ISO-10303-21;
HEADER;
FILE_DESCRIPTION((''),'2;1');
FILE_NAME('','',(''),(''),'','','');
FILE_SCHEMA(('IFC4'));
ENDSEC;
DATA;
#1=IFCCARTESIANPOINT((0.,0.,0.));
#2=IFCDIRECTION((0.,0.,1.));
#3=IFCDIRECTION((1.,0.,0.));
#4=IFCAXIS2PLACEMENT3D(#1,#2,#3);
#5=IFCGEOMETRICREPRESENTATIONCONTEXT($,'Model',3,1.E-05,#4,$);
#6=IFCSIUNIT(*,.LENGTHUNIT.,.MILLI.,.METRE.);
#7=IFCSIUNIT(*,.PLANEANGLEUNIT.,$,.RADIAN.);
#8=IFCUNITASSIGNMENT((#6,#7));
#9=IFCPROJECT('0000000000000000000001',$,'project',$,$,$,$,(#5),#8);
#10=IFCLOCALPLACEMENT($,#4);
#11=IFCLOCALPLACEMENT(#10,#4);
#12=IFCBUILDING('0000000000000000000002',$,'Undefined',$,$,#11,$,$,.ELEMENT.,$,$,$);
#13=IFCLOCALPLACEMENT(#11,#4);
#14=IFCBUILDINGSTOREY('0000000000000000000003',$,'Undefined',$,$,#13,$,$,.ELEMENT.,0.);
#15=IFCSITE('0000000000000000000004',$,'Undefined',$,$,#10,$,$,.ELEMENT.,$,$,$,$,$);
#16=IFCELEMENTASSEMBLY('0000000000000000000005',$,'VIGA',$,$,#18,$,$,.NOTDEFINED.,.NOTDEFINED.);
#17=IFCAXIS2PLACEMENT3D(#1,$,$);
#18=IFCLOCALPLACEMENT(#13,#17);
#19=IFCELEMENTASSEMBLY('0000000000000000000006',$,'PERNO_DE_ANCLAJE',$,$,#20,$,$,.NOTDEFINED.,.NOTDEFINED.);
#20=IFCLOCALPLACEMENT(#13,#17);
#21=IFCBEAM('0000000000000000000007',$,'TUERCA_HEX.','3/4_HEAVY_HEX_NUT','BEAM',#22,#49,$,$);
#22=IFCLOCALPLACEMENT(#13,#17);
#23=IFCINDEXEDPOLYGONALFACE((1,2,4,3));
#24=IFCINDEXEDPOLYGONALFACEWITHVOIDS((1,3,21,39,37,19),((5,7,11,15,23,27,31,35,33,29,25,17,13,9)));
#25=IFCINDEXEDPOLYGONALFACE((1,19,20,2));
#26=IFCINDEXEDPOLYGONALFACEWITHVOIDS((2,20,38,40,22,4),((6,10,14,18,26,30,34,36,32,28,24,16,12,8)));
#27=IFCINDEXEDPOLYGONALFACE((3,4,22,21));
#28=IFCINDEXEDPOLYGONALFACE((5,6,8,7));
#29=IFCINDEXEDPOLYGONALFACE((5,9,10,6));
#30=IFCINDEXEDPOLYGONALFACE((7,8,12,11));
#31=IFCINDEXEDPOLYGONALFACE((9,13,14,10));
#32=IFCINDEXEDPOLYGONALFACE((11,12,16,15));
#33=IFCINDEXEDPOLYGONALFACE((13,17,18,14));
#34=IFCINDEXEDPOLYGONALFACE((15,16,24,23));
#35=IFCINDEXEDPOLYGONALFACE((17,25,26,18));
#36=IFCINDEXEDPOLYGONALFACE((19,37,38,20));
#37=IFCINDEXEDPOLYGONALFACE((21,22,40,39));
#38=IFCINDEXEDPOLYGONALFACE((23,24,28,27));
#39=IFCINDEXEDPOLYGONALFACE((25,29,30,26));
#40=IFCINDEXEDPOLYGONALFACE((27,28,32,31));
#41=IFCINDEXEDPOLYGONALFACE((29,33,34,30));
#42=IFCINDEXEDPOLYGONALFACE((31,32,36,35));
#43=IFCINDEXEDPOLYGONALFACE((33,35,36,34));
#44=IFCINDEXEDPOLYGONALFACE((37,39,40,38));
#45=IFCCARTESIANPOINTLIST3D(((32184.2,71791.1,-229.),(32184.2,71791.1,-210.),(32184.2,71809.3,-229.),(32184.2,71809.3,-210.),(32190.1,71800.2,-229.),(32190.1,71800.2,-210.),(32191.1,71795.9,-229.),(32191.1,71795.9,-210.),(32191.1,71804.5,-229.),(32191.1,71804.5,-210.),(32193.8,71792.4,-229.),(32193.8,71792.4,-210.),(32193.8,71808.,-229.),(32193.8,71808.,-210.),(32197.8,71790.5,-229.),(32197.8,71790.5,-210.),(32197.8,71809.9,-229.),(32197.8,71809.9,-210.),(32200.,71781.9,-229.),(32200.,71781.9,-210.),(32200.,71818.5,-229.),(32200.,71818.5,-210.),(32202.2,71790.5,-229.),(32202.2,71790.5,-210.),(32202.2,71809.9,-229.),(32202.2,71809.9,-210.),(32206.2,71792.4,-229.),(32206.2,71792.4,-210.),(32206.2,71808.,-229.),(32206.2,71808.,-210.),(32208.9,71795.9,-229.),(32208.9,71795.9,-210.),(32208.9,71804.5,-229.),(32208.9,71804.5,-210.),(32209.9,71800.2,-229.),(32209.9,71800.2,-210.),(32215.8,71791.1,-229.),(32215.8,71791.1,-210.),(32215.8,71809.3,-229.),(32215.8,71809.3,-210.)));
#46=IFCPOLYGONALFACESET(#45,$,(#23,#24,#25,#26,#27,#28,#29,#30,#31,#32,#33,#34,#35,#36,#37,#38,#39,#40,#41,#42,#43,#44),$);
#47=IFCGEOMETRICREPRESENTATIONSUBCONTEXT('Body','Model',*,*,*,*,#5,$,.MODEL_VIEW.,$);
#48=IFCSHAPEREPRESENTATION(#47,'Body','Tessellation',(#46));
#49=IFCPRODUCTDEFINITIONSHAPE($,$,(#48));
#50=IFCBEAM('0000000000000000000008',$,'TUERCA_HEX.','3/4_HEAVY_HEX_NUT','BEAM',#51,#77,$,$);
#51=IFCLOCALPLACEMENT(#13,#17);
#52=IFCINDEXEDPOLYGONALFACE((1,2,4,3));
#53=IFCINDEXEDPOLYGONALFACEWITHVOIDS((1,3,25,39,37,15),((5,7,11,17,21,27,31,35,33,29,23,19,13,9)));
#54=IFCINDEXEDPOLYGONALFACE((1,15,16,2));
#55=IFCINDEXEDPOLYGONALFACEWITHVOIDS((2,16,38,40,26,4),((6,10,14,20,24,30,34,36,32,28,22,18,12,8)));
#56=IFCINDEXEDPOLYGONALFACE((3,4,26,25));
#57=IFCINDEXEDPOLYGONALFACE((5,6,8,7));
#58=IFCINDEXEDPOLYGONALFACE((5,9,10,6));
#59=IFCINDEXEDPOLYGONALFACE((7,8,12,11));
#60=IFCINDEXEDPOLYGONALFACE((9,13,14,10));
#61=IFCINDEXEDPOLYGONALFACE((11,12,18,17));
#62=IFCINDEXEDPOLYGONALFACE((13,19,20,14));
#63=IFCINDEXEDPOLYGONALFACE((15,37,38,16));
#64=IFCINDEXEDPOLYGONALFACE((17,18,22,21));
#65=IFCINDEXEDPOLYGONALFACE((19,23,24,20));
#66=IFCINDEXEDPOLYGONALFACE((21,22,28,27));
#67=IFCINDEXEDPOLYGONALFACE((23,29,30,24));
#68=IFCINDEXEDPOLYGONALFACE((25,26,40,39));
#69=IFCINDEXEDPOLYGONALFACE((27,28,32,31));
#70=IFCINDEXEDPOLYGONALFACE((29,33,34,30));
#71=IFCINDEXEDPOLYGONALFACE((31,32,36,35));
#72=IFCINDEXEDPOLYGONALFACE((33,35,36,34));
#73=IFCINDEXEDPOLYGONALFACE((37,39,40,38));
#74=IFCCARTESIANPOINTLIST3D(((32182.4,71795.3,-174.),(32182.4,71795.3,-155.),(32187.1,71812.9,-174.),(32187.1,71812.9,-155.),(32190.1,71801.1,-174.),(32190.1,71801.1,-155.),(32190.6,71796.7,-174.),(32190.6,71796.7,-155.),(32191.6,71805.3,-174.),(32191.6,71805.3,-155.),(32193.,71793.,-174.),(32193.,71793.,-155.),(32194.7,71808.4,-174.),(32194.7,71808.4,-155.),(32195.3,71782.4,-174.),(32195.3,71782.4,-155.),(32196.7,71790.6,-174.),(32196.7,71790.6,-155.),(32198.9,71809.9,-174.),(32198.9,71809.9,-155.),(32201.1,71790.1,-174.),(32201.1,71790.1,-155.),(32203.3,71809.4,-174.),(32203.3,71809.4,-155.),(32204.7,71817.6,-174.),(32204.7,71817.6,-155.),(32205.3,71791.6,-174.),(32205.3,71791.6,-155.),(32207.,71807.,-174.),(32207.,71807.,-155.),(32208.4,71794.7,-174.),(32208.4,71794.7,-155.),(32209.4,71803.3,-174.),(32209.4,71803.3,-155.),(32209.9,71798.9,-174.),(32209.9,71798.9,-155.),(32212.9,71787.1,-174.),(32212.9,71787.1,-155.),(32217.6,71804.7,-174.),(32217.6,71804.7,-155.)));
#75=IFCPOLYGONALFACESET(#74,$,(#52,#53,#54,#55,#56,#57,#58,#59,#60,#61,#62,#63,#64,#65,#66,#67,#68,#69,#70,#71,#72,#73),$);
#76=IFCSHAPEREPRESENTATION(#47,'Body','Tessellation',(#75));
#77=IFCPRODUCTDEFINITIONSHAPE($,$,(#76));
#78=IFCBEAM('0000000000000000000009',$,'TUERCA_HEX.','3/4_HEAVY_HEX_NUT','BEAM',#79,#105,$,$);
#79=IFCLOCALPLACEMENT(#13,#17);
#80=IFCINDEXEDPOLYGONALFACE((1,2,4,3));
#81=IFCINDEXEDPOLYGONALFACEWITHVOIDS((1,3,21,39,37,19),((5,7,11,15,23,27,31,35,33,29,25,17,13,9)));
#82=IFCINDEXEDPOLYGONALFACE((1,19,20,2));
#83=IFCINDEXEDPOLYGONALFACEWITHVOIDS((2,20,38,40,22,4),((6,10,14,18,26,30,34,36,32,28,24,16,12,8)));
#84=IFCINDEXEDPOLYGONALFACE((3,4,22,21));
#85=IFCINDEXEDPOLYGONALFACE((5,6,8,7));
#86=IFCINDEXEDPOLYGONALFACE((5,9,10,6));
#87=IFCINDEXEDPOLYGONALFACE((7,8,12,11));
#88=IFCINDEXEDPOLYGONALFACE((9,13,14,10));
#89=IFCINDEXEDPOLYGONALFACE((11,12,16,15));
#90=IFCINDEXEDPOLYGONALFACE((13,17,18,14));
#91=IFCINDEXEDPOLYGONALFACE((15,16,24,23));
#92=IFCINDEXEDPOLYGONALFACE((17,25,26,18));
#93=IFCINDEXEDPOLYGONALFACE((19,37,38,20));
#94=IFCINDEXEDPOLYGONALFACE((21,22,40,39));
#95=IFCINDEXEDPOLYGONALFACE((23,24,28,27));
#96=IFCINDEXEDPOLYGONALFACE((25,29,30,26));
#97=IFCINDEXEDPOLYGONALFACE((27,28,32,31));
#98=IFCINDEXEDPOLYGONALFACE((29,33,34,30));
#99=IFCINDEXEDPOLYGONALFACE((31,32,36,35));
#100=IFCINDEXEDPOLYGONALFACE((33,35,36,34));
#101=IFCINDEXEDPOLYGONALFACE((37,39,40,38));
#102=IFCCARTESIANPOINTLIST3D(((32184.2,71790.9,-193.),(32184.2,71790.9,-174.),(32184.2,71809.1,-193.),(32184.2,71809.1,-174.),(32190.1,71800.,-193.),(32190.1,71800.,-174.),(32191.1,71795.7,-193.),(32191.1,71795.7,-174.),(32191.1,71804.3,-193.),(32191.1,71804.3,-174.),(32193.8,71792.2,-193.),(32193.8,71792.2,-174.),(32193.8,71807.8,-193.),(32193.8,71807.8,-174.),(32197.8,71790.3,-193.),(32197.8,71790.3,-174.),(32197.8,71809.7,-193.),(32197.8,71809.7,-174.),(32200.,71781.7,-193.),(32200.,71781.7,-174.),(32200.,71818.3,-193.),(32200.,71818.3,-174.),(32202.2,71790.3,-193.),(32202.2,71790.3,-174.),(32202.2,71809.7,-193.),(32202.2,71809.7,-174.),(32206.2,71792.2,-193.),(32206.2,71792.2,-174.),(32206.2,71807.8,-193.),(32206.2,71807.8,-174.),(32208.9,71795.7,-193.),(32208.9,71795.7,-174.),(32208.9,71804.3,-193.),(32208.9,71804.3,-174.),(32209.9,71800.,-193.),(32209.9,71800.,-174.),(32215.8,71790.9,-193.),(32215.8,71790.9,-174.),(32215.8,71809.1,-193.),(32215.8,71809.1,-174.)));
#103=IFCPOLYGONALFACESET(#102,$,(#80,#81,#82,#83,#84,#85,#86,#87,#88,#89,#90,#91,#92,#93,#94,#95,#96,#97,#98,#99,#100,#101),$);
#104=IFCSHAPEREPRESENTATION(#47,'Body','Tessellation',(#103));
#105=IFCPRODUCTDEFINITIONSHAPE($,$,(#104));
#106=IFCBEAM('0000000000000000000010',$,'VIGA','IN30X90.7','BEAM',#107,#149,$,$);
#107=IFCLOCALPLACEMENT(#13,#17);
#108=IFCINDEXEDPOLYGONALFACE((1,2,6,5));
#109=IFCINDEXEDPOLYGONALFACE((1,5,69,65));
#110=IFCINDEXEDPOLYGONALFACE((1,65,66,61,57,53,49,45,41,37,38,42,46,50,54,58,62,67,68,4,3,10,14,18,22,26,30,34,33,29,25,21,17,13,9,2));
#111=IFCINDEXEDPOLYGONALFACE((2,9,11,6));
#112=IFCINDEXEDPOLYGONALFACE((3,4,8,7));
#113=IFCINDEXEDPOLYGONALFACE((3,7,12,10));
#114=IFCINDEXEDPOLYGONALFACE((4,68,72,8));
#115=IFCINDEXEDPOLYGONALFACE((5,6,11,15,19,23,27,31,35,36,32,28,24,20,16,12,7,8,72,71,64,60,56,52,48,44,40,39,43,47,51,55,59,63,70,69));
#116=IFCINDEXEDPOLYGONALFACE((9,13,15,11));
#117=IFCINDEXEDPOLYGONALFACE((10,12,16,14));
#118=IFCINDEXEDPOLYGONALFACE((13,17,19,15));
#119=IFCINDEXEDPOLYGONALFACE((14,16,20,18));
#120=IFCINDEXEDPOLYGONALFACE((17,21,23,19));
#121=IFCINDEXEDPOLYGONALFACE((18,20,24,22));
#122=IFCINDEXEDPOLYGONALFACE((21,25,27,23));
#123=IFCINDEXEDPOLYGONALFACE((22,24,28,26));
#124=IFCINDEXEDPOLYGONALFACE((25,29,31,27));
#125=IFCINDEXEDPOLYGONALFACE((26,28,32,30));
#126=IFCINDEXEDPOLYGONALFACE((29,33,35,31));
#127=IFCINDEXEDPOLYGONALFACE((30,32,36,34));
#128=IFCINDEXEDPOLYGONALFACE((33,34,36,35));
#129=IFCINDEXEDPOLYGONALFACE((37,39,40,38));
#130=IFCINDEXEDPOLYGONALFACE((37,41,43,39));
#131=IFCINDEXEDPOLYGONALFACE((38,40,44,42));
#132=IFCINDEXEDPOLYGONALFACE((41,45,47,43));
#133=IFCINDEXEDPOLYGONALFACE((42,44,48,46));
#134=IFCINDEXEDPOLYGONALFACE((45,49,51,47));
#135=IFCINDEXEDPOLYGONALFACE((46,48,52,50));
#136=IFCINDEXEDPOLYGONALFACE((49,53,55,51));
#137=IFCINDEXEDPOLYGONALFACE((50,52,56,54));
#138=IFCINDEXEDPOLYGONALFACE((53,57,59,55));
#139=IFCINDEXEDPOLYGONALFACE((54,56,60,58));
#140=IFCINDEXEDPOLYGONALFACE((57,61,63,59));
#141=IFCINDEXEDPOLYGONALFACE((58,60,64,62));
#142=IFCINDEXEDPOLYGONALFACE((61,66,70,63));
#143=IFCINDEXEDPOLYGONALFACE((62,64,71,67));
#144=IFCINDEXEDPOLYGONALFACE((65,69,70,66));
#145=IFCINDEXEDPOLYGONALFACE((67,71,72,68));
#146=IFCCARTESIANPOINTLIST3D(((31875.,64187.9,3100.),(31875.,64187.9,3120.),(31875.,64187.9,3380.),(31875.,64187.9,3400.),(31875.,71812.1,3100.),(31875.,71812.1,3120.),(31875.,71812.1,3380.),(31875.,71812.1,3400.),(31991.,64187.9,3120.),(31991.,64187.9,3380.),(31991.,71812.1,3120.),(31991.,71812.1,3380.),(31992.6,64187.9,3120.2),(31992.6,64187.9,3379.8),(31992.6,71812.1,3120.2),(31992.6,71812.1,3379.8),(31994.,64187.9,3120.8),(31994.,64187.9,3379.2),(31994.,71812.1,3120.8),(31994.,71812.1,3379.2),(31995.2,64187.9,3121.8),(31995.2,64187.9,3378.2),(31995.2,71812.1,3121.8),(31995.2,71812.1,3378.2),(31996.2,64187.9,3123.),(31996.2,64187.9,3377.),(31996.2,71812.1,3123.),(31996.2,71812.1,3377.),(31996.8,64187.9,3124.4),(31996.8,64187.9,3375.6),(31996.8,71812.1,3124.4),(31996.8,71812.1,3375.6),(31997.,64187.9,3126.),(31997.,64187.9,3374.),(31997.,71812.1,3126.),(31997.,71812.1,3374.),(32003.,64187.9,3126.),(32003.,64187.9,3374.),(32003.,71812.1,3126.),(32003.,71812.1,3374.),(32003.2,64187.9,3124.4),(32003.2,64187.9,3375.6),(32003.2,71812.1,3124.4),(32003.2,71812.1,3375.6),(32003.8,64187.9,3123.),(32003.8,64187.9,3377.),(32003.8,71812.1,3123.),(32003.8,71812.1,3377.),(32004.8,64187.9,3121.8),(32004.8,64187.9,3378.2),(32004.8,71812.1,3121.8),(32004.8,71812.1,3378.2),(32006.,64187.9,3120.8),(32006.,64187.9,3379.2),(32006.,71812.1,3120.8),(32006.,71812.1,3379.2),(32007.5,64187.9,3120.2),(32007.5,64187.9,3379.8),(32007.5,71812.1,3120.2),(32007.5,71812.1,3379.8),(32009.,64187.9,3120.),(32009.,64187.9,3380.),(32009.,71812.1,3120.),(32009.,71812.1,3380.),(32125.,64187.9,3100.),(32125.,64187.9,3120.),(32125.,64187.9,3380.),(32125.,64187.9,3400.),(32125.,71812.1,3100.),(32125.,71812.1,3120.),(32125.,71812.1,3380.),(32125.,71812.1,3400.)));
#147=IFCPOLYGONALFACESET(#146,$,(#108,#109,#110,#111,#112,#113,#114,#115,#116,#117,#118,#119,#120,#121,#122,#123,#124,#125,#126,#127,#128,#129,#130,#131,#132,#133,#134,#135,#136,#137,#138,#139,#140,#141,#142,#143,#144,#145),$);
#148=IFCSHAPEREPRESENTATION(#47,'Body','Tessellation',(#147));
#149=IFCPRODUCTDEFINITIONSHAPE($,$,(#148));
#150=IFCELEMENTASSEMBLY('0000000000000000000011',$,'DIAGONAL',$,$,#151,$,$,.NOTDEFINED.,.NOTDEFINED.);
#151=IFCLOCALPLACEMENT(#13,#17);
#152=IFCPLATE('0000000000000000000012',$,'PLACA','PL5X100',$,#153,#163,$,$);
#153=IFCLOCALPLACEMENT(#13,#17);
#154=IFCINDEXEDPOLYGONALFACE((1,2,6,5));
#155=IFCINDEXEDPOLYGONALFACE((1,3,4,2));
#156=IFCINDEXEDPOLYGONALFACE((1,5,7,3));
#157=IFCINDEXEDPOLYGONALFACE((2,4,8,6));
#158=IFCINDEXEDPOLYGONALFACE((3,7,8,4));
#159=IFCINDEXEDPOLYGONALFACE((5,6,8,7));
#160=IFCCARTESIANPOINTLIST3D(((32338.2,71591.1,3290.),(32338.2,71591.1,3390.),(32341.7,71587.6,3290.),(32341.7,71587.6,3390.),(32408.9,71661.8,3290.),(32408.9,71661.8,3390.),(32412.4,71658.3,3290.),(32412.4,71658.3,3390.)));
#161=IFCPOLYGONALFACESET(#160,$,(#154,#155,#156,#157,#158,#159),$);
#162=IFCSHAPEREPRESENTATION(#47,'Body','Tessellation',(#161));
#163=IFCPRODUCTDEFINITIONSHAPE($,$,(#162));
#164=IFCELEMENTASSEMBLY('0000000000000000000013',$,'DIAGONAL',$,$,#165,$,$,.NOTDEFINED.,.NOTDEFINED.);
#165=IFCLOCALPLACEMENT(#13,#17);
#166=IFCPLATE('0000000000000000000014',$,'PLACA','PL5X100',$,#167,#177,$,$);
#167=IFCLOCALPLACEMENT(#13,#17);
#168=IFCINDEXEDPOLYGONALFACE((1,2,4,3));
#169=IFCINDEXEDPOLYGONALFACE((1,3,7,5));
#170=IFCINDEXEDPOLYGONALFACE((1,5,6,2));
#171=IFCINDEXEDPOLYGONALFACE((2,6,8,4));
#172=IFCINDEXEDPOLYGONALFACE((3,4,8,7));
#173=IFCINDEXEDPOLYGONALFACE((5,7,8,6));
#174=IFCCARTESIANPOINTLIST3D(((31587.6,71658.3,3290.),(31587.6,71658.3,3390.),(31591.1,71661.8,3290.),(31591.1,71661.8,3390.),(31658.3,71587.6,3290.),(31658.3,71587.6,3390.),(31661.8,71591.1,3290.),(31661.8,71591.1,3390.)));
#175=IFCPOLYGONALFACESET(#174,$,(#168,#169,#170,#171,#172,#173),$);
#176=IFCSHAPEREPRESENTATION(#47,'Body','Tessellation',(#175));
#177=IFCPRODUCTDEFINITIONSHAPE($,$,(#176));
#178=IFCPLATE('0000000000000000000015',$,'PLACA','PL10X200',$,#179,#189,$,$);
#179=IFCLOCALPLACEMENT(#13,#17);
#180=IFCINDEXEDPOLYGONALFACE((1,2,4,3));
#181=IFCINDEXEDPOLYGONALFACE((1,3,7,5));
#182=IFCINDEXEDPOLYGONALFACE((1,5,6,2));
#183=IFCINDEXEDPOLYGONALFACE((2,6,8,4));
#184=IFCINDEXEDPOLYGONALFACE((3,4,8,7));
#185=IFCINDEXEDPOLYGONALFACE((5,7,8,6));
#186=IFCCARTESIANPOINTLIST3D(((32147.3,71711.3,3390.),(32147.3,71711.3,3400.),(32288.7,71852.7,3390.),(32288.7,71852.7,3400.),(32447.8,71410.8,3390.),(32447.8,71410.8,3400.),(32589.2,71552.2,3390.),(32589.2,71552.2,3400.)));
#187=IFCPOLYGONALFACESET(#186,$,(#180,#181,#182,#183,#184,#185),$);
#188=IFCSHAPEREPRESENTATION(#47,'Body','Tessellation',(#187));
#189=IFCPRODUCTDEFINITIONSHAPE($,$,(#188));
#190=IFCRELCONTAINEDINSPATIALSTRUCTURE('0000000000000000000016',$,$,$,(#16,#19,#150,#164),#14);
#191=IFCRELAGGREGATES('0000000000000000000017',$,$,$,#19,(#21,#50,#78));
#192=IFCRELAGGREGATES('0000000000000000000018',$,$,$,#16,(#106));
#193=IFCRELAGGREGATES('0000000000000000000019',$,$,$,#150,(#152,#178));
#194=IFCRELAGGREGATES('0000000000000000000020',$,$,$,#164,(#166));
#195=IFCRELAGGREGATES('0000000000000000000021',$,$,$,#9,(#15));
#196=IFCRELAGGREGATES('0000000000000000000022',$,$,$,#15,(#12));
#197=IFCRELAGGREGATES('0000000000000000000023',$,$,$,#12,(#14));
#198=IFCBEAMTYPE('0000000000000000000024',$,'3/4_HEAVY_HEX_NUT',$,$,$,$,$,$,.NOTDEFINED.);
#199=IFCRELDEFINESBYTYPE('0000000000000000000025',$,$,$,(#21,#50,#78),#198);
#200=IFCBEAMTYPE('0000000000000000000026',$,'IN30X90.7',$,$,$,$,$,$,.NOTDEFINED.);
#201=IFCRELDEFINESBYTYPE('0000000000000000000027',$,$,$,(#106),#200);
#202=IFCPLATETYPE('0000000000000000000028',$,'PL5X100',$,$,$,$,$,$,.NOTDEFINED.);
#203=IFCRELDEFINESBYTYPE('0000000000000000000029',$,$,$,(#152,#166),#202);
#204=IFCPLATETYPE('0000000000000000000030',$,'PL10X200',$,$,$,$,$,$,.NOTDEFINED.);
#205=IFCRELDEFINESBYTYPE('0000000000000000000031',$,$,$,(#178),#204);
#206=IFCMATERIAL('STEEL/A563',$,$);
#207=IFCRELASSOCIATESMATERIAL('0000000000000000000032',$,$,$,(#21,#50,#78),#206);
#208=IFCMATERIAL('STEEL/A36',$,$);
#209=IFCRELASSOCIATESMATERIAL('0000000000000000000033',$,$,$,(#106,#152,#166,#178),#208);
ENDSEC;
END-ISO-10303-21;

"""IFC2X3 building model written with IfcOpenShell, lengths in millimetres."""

from ifc_helpers import new_model, si_unit, frame, origin_with_axes, origin_2d_with_axis, place, context, subcontext, project, spatial, polyline, i_section, outline, extrude, material, type_object, element, aggregate, save


model = new_model("IFC2X3")

# Units and contexts
model_context = context("Model", 3, precision=1e-05, world=origin_with_axes())
body_context = subcontext(model_context, "Body", "Model", "MODEL_VIEW")
ifc_project = project(units=[si_unit("LENGTHUNIT", "METRE", prefix="MILLI"), si_unit("PLANEANGLEUNIT", "RADIAN")], contexts=[model_context])

# Site, building, storey
site_placement = place(None, origin_with_axes())
site = spatial("IfcSite", under=ifc_project, at=site_placement, Name="Undefined", CompositionType="ELEMENT")
building_placement = place(site_placement, origin_with_axes())
building = spatial("IfcBuilding", under=site, at=building_placement, Name="Undefined", CompositionType="ELEMENT")
storey_placement = place(building_placement, origin_with_axes())
storey = spatial("IfcBuildingStorey", under=building, at=storey_placement, Name="Undefined", CompositionType="ELEMENT", Elevation=0.0)

# Element assemblies
assembly_1_placement = place(storey_placement, origin_with_axes())
assembly_1 = element("IfcElementAssembly", 1, at=assembly_1_placement, inside=storey, Name="VIGA", AssemblyPlace="NOTDEFINED", PredefinedType="NOTDEFINED")
ifc_material_1 = material(Name="STEEL/A36")
ifc_material_2 = material(Name="STEEL/A563")
assembly_2_placement = place(storey_placement, origin_with_axes())
assembly_2 = element("IfcElementAssembly", 2, at=assembly_2_placement, inside=storey, Name="PERNO_DE_ANCLAJE", AssemblyPlace="NOTDEFINED", PredefinedType="NOTDEFINED")

# Beams
beam_type_1 = type_object("IfcBeamType", Name="3/4_HEAVY_HEX_NUT", PredefinedType="NOTDEFINED")
beam_1_placement = place(assembly_2_placement, frame((32200.0, 71800.2, -210.0), z_axis=(1.0, 0.0, 0.0), x_axis=(0.0, 0.0, -1.0)))
beam_1 = element("IfcBeam", 3, at=beam_1_placement, type_object=beam_type_1, material=ifc_material_2, Name="TUERCA_HEX.", Description="3/4_HEAVY_HEX_NUT", ObjectType="BEAM", context=body_context, shape_type="SweptSolid", body=[
    extrude(outline(polyline([(-9.1, -15.8), (-18.3, 0.0), (-9.1, 15.8), (9.1, 15.8), (18.3, 0.0), (9.1, -15.8), (-9.1, -15.8)]), holes=[polyline([(7.8, 6.2), (4.3, 8.9), (0.0, 9.9), (-4.3, 8.9), (-7.8, 6.2), (-9.7, 2.2), (-9.7, -2.2), (-7.8, -6.2), (-4.3, -8.9), (0.0, -9.9), (4.3, -8.9), (7.8, -6.2), (9.7, -2.2), (9.7, 2.2), (7.8, 6.2)])]), frame((19.0, 0.0, 0.0), z_axis=(-1.0, 0.0, 0.0), x_axis=(0.0, -1.0, 0.0)), (0.0, 0.0, 1.0), 19.0),
])
beam_2_placement = place(assembly_2_placement, frame((32200.0, 71800.0, -155.0), z_axis=(0.707107, 0.707107, 0.0), x_axis=(0.0, 0.0, -1.0)))
beam_2 = element("IfcBeam", 4, at=beam_2_placement, type_object=beam_type_1, material=ifc_material_2, Name="TUERCA_HEX.", Description="3/4_HEAVY_HEX_NUT", ObjectType="BEAM", context=body_context, shape_type="SweptSolid", body=[
    extrude(outline(polyline([(-9.1, -15.8), (-18.3, 0.0), (-9.1, 15.8), (9.1, 15.8), (18.3, 0.0), (9.1, -15.8), (-9.1, -15.8)]), holes=[polyline([(7.8, 6.2), (4.3, 8.9), (0.0, 9.9), (-4.3, 8.9), (-7.8, 6.2), (-9.7, 2.2), (-9.7, -2.2), (-7.8, -6.2), (-4.3, -8.9), (0.0, -9.9), (4.3, -8.9), (7.8, -6.2), (9.7, -2.2), (9.7, 2.2), (7.8, 6.2)])]), frame((19.0, 0.0, 0.0), z_axis=(-1.0, 0.0, 0.0), x_axis=(0.0, -1.0, 0.0)), (0.0, 0.0, 1.0), 19.0),
])
beam_3_placement = place(assembly_2_placement, frame((32200.0, 71800.0, -174.0), z_axis=(1.0, 0.0, 0.0), x_axis=(0.0, 0.0, -1.0)))
beam_3 = element("IfcBeam", 5, at=beam_3_placement, type_object=beam_type_1, material=ifc_material_2, Name="TUERCA_HEX.", Description="3/4_HEAVY_HEX_NUT", ObjectType="BEAM", context=body_context, shape_type="SweptSolid", body=[
    extrude(outline(polyline([(-9.1, -15.8), (-18.3, 0.0), (-9.1, 15.8), (9.1, 15.8), (18.3, 0.0), (9.1, -15.8), (-9.1, -15.8)]), holes=[polyline([(7.8, 6.2), (4.3, 8.9), (0.0, 9.9), (-4.3, 8.9), (-7.8, 6.2), (-9.7, 2.2), (-9.7, -2.2), (-7.8, -6.2), (-4.3, -8.9), (0.0, -9.9), (4.3, -8.9), (7.8, -6.2), (9.7, -2.2), (9.7, 2.2), (7.8, 6.2)])]), frame((19.0, 0.0, 0.0), z_axis=(-1.0, 0.0, 0.0), x_axis=(0.0, -1.0, 0.0)), (0.0, 0.0, 1.0), 19.0),
])
aggregate(assembly_2, [beam_1, beam_2, beam_3])
beam_type_2 = type_object("IfcBeamType", Name="IN30X90.7", PredefinedType="NOTDEFINED")
beam_4_placement = place(assembly_1_placement, frame((32000.0, 71812.1, 3250.0), z_axis=(0.0, 0.0, 1.0), x_axis=(0.0, -1.0, 0.0)))
beam_4 = element("IfcBeam", 6, at=beam_4_placement, type_object=beam_type_2, material=ifc_material_1, Name="VIGA", Description="IN30X90.7", ObjectType="BEAM", context=body_context, shape_type="SweptSolid", body=[
    extrude(i_section(OverallWidth=250.0, OverallDepth=300.0, WebThickness=6.0, FlangeThickness=20.0, FilletRadius=6.0, at=origin_2d_with_axis()), frame((7624.2, 0.0, 0.0), z_axis=(-1.0, 0.0, 0.0), x_axis=(0.0, -1.0, 0.0)), (0.0, 0.0, 1.0), 7624.2),
])

# Element assemblies, plates
assembly_3_placement = place(storey_placement, origin_with_axes())
assembly_3 = element("IfcElementAssembly", 7, at=assembly_3_placement, inside=storey, Name="DIAGONAL", AssemblyPlace="NOTDEFINED", PredefinedType="NOTDEFINED")
plate_type_1 = type_object("IfcPlateType", Name="PL5X100", PredefinedType="NOTDEFINED")
plate_1_placement = place(assembly_3_placement, frame((32339.9, 71589.4, 3390.0), z_axis=(0.707107, -0.707107, 0.0), x_axis=(0.0, 0.0, -1.0)))
plate_1 = element("IfcPlate", 8, at=plate_1_placement, type_object=plate_type_1, material=ifc_material_1, Name="PLACA", Description="PL5X100", context=body_context, shape_type="SweptSolid", body=[
    extrude(outline(polyline([(0.0, 0.0), (100.0, 0.0), (100.0, 100.0), (0.0, 100.0), (0.0, 0.0)])), frame((0.0, 0.0, -2.5), z_axis=(0.0, 0.0, 1.0), x_axis=(1.0, 0.0, 0.0)), (0.0, 0.0, 1.0), 5.0),
])
assembly_4_placement = place(storey_placement, origin_with_axes())
assembly_4 = element("IfcElementAssembly", 9, at=assembly_4_placement, inside=storey, Name="DIAGONAL", AssemblyPlace="NOTDEFINED", PredefinedType="NOTDEFINED")
plate_2_placement = place(assembly_4_placement, frame((31589.4, 71660.1, 3390.0), z_axis=(-0.707107, -0.707107, 0.0), x_axis=(0.0, 0.0, -1.0)))
plate_2 = element("IfcPlate", 10, at=plate_2_placement, type_object=plate_type_1, material=ifc_material_1, Name="PLACA", Description="PL5X100", context=body_context, shape_type="SweptSolid", body=[
    extrude(outline(polyline([(0.0, 0.0), (100.0, 0.0), (100.0, 100.0), (0.0, 100.0), (0.0, 0.0)])), frame((0.0, 0.0, -2.5), z_axis=(0.0, 0.0, 1.0), x_axis=(1.0, 0.0, 0.0)), (0.0, 0.0, 1.0), 5.0),
])

# Plate
plate_type_2 = type_object("IfcPlateType", Name="PL10X200", PredefinedType="NOTDEFINED")
plate_3_placement = place(assembly_3_placement, frame((32218.0, 71782.0, 3395.0), z_axis=(0.0, 0.0, -1.0), x_axis=(0.707107, -0.707107, 0.0)))
plate_3 = element("IfcPlate", 11, at=plate_3_placement, type_object=plate_type_2, material=ifc_material_1, Name="PLACA", Description="PL10X200", context=body_context, shape_type="SweptSolid", body=[
    extrude(outline(polyline([(0.0, -100.0), (0.0, 100.0), (425.0, 100.0), (425.0, -100.0), (0.0, -100.0)])), frame((0.0, 0.0, -5.0), z_axis=(0.0, 0.0, 1.0), x_axis=(1.0, 0.0, 0.0)), (0.0, 0.0, 1.0), 10.0),
])
aggregate(assembly_1, [beam_4])

aggregate(assembly_3, [plate_1, plate_3])
aggregate(assembly_4, [plate_2])

save(model, "model.ifc")
